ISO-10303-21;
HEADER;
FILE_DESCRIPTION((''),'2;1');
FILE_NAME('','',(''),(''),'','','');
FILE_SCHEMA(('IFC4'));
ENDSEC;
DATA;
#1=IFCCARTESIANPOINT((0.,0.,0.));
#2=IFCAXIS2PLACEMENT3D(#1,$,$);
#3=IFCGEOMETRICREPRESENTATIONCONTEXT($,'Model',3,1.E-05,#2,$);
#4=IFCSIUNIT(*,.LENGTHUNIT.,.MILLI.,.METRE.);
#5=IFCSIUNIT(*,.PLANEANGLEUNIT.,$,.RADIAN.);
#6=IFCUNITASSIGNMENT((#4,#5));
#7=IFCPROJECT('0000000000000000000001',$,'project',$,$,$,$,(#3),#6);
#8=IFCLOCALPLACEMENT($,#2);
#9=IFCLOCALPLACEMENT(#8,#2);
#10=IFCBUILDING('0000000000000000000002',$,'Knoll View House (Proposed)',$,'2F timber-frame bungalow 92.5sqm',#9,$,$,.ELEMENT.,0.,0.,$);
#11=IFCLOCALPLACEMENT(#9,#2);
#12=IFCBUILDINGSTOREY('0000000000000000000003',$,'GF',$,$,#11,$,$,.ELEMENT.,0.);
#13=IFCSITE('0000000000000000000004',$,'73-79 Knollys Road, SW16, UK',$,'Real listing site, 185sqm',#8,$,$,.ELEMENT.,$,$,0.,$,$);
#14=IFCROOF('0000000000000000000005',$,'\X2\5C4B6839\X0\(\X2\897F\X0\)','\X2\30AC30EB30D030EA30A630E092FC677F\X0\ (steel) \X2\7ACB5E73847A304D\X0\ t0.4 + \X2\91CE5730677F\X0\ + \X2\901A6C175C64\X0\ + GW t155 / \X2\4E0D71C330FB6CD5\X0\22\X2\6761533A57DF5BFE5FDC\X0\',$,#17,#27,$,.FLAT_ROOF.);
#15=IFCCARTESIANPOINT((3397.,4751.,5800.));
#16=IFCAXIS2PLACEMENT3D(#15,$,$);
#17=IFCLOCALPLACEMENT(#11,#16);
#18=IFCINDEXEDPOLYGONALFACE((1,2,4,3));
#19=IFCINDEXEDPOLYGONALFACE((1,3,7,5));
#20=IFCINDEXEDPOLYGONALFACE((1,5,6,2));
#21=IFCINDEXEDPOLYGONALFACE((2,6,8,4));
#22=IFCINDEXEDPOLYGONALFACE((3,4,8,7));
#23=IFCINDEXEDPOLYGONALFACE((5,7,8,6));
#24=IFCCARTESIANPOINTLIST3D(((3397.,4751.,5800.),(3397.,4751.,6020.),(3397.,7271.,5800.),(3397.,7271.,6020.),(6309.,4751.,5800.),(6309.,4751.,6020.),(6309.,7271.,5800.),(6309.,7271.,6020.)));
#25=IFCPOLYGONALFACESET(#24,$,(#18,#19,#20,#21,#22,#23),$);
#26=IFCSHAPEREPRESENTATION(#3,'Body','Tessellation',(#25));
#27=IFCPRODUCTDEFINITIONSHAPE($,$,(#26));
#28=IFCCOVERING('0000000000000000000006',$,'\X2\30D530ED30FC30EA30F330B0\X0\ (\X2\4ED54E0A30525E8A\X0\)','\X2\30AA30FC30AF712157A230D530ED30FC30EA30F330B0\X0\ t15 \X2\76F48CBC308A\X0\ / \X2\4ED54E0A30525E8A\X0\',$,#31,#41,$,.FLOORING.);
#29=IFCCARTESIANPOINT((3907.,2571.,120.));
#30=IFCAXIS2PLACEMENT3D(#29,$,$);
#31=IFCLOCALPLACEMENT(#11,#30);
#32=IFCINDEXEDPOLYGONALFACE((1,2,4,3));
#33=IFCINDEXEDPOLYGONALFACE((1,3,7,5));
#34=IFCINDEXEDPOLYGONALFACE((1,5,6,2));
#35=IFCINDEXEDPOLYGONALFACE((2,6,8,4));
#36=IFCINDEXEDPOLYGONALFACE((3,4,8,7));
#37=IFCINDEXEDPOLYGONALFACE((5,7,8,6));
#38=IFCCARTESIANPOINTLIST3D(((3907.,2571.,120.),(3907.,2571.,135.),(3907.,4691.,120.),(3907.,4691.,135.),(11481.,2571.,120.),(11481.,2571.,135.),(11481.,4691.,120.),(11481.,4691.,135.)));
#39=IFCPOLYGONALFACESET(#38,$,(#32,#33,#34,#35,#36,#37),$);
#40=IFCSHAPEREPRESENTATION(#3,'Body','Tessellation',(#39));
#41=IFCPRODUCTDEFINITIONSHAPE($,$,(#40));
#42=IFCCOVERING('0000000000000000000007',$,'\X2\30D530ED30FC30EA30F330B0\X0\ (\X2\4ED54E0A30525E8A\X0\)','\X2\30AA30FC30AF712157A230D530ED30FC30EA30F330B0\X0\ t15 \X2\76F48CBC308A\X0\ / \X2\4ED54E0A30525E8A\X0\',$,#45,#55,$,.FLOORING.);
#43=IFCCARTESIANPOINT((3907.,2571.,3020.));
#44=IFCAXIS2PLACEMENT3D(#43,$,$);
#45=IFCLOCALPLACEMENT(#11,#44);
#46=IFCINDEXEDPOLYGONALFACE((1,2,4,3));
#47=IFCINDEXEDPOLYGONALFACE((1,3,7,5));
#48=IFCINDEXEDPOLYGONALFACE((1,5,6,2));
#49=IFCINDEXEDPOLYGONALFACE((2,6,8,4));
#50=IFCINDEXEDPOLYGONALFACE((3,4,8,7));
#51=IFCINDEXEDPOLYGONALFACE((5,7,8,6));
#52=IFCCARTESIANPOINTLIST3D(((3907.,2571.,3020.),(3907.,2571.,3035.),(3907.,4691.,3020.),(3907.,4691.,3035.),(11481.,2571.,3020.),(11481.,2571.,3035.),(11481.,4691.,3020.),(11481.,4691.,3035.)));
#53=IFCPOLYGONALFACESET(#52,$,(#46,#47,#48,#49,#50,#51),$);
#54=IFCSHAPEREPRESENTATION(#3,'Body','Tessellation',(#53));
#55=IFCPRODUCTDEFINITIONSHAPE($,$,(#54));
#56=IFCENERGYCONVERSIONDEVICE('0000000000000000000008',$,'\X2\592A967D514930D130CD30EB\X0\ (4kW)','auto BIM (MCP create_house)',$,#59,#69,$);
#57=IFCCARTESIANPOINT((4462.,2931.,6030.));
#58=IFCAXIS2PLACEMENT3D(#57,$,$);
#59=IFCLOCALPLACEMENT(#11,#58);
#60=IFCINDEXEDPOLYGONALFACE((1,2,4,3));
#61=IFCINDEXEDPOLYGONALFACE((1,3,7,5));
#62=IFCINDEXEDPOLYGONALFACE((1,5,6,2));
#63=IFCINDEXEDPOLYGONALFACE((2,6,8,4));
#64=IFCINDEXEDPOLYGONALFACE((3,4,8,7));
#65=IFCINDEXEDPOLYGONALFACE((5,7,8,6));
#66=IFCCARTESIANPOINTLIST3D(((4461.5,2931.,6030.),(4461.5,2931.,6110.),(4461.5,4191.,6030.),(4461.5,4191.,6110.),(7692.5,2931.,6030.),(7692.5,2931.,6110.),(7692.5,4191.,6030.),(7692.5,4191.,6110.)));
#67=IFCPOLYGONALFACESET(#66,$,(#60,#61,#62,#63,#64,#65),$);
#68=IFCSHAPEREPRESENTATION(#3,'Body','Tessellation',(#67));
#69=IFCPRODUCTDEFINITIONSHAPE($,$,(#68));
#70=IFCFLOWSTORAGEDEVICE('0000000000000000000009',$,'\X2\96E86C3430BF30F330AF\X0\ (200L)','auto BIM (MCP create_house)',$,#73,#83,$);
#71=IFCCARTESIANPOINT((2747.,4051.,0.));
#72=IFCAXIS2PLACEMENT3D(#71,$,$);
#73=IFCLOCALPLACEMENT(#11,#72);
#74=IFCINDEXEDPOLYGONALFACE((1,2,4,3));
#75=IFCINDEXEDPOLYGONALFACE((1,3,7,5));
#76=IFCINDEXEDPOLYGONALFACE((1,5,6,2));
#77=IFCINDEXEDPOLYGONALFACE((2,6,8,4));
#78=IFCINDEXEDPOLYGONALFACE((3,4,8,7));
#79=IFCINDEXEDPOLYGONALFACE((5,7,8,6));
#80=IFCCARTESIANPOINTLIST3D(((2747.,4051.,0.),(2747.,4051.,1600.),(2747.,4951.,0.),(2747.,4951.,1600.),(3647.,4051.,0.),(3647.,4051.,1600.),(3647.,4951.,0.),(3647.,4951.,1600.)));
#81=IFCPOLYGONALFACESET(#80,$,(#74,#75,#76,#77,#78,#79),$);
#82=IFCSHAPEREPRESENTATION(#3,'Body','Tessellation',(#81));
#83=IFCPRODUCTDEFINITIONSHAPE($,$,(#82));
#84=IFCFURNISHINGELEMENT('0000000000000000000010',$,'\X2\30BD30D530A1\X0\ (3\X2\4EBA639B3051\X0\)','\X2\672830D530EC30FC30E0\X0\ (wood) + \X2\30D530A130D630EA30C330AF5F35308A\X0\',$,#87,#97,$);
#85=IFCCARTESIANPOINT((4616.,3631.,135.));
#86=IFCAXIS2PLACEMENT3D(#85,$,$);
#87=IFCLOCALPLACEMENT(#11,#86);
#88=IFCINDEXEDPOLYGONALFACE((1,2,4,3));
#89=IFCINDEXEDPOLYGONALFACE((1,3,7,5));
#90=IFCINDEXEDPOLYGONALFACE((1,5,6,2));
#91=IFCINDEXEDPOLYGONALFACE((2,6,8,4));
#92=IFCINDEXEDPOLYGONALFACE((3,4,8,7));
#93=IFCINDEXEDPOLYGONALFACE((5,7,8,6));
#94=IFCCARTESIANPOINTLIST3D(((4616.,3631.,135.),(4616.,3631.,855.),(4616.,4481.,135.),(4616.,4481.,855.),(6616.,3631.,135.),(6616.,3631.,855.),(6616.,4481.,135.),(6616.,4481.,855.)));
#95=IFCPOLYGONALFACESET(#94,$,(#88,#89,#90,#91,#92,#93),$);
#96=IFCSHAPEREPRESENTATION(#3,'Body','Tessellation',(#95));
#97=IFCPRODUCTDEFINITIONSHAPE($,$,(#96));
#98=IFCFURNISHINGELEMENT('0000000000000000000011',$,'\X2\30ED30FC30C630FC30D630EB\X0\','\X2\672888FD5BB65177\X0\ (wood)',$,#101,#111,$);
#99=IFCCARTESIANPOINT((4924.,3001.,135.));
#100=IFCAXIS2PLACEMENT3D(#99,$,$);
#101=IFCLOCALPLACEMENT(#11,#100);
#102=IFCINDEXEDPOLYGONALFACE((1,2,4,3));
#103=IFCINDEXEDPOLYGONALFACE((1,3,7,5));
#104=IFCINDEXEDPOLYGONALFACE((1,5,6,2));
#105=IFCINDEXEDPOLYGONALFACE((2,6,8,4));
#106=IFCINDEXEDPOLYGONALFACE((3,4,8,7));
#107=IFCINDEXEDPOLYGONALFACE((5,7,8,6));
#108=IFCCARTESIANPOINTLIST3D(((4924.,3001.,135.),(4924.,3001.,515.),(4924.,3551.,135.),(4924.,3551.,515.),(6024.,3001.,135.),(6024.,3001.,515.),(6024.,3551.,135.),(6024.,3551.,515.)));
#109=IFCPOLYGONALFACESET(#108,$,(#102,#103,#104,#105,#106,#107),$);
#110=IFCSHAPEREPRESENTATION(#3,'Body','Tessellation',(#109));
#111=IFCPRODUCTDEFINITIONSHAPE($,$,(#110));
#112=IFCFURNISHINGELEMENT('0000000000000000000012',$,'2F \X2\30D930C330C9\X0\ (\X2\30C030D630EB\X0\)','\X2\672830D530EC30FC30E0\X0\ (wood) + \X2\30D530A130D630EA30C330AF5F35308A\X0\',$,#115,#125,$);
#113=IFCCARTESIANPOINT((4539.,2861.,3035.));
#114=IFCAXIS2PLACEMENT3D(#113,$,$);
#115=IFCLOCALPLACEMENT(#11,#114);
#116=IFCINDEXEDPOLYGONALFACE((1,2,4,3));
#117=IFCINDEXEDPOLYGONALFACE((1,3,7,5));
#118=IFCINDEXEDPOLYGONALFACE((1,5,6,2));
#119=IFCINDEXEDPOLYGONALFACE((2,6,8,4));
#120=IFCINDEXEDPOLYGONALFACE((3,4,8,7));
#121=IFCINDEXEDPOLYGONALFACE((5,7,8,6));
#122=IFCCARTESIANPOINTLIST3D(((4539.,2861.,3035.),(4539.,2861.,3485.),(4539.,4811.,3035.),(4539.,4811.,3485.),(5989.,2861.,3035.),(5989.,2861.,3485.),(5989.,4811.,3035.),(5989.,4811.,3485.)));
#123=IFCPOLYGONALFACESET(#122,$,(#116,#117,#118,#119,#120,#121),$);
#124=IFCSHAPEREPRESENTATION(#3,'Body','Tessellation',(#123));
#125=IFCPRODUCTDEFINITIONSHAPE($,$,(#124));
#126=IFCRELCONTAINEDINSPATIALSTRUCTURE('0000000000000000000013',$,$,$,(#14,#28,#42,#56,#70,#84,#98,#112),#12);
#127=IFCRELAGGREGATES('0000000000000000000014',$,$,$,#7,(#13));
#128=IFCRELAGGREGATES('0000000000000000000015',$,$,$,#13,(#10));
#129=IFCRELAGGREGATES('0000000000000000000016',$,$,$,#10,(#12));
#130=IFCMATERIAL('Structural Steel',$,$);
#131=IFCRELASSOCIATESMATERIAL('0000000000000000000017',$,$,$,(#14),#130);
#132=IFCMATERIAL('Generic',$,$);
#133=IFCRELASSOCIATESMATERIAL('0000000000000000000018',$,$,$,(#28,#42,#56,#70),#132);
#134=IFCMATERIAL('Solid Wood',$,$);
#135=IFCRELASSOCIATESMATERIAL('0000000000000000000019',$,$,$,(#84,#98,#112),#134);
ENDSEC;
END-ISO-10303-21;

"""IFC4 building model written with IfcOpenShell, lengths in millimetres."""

from ifc_helpers import new_model, si_unit, frame, frame_2d, origin, place, context, project, spatial, rectangle, extrude, material, element, save


model = new_model("IFC4")

# Units and contexts
model_context = context("Model", 3, precision=1e-05, world=origin())
ifc_project = project(units=[si_unit("LENGTHUNIT", "METRE", prefix="MILLI"), si_unit("PLANEANGLEUNIT", "RADIAN")], contexts=[model_context])

# Site, building, storey
site_placement = place(None, origin())
site = spatial("IfcSite", under=ifc_project, at=site_placement, Name="73-79 Knollys Road, SW16, UK", ObjectType="Real listing site, 185sqm", CompositionType="ELEMENT", RefElevation=0.0)
building_placement = place(site_placement, origin())
building = spatial("IfcBuilding", under=site, at=building_placement, Name="Knoll View House (Proposed)", ObjectType="2F timber-frame bungalow 92.5sqm", CompositionType="ELEMENT", ElevationOfRefHeight=0.0, ElevationOfTerrain=0.0)
storey_placement = place(building_placement, origin())
storey = spatial("IfcBuildingStorey", under=building, at=storey_placement, Name="GF", CompositionType="ELEMENT", Elevation=0.0)

# Shared definitions
ifc_material_1 = material(Name="Solid Wood")

# Roof
ifc_material_2 = material(Name="Structural Steel")
roof_1_placement = place(storey_placement, frame((3397.0, 4751.0, 5800.0)))
element("IfcRoof", 1, at=roof_1_placement, inside=storey, material=ifc_material_2, Name="屋根(西)", Description="ガルバリウム鋼板 (steel) 立平葺き t0.4 + 野地板 + 通気層 + GW t155 / 不燃・法22条区域対応", PredefinedType="FLAT_ROOF", context=model_context, shape_type="SweptSolid", body=[
    extrude(rectangle(XDim=2912.0, YDim=2520.0, at=frame_2d((1456.0, 1260.0))), frame((3397.0, 4751.0, 5800.0)), (0.0, 0.0, 1.0), 220.0),
])

# Coverings
ifc_material_3 = material(Name="Generic")
covering_1_placement = place(storey_placement, frame((3907.0, 2571.0, 120.0)))
element("IfcCovering", 2, at=covering_1_placement, inside=storey, material=ifc_material_3, Name="フローリング (仕上げ床)", Description="オーク無垢フローリング t15 直貼り / 仕上げ床", PredefinedType="FLOORING", context=model_context, shape_type="SweptSolid", body=[
    extrude(rectangle(XDim=7574.0, YDim=2120.0, at=frame_2d((3787.0, 1060.0))), frame((3907.0, 2571.0, 120.0)), (0.0, 0.0, 1.0), 15.0),
])
covering_2_placement = place(storey_placement, frame((3907.0, 2571.0, 3020.0)))
element("IfcCovering", 3, at=covering_2_placement, inside=storey, material=ifc_material_3, Name="フローリング (仕上げ床)", Description="オーク無垢フローリング t15 直貼り / 仕上げ床", PredefinedType="FLOORING", context=model_context, shape_type="SweptSolid", body=[
    extrude(rectangle(XDim=7574.0, YDim=2120.0, at=frame_2d((3787.0, 1060.0))), frame((3907.0, 2571.0, 3020.0)), (0.0, 0.0, 1.0), 15.0),
])

# Energy conversion device
energy_conversion_device_placement = place(storey_placement, frame((4462.0, 2931.0, 6030.0)))
element("IfcEnergyConversionDevice", 4, at=energy_conversion_device_placement, inside=storey, material=ifc_material_3, Name="太陽光パネル (4kW)", Description="auto BIM (MCP create_house)", context=model_context, shape_type="SweptSolid", body=[
    extrude(rectangle(XDim=3231.0, YDim=1260.0, at=frame_2d((1615.0, 630.0))), frame((4462.0, 2931.0, 6030.0)), (0.0, 0.0, 1.0), 80.0),
])

# Flow storage device
flow_storage_device_placement = place(storey_placement, frame((2747.0, 4051.0, 0.0)))
element("IfcFlowStorageDevice", 5, at=flow_storage_device_placement, inside=storey, material=ifc_material_3, Name="雨水タンク (200L)", Description="auto BIM (MCP create_house)", context=model_context, shape_type="SweptSolid", body=[
    extrude(rectangle(XDim=900.0, YDim=900.0, at=frame_2d((450.0, 450.0))), frame((2747.0, 4051.0, 0.0)), (0.0, 0.0, 1.0), 1600.0),
])

# Furnishing elements
furnishing_1_placement = place(storey_placement, frame((4616.0, 3631.0, 135.0)))
element("IfcFurnishingElement", 6, at=furnishing_1_placement, inside=storey, material=ifc_material_1, Name="ソファ (3人掛け)", Description="木フレーム (wood) + ファブリック張り", context=model_context, shape_type="SweptSolid", body=[
    extrude(rectangle(XDim=2000.0, YDim=850.0, at=frame_2d((1000.0, 425.0))), frame((4616.0, 3631.0, 135.0)), (0.0, 0.0, 1.0), 720.0),
])
furnishing_2_placement = place(storey_placement, frame((4924.0, 3001.0, 135.0)))
element("IfcFurnishingElement", 7, at=furnishing_2_placement, inside=storey, material=ifc_material_1, Name="ローテーブル", Description="木製家具 (wood)", context=model_context, shape_type="SweptSolid", body=[
    extrude(rectangle(XDim=1100.0, YDim=550.0, at=frame_2d((550.0, 275.0))), frame((4924.0, 3001.0, 135.0)), (0.0, 0.0, 1.0), 380.0),
])
furnishing_3_placement = place(storey_placement, frame((4539.0, 2861.0, 3035.0)))
element("IfcFurnishingElement", 8, at=furnishing_3_placement, inside=storey, material=ifc_material_1, Name="2F ベッド (ダブル)", Description="木フレーム (wood) + ファブリック張り", context=model_context, shape_type="SweptSolid", body=[
    extrude(rectangle(XDim=1450.0, YDim=1950.0, at=frame_2d((725.0, 975.0))), frame((4539.0, 2861.0, 3035.0)), (0.0, 0.0, 1.0), 450.0),
])

save(model, "model.ifc")
